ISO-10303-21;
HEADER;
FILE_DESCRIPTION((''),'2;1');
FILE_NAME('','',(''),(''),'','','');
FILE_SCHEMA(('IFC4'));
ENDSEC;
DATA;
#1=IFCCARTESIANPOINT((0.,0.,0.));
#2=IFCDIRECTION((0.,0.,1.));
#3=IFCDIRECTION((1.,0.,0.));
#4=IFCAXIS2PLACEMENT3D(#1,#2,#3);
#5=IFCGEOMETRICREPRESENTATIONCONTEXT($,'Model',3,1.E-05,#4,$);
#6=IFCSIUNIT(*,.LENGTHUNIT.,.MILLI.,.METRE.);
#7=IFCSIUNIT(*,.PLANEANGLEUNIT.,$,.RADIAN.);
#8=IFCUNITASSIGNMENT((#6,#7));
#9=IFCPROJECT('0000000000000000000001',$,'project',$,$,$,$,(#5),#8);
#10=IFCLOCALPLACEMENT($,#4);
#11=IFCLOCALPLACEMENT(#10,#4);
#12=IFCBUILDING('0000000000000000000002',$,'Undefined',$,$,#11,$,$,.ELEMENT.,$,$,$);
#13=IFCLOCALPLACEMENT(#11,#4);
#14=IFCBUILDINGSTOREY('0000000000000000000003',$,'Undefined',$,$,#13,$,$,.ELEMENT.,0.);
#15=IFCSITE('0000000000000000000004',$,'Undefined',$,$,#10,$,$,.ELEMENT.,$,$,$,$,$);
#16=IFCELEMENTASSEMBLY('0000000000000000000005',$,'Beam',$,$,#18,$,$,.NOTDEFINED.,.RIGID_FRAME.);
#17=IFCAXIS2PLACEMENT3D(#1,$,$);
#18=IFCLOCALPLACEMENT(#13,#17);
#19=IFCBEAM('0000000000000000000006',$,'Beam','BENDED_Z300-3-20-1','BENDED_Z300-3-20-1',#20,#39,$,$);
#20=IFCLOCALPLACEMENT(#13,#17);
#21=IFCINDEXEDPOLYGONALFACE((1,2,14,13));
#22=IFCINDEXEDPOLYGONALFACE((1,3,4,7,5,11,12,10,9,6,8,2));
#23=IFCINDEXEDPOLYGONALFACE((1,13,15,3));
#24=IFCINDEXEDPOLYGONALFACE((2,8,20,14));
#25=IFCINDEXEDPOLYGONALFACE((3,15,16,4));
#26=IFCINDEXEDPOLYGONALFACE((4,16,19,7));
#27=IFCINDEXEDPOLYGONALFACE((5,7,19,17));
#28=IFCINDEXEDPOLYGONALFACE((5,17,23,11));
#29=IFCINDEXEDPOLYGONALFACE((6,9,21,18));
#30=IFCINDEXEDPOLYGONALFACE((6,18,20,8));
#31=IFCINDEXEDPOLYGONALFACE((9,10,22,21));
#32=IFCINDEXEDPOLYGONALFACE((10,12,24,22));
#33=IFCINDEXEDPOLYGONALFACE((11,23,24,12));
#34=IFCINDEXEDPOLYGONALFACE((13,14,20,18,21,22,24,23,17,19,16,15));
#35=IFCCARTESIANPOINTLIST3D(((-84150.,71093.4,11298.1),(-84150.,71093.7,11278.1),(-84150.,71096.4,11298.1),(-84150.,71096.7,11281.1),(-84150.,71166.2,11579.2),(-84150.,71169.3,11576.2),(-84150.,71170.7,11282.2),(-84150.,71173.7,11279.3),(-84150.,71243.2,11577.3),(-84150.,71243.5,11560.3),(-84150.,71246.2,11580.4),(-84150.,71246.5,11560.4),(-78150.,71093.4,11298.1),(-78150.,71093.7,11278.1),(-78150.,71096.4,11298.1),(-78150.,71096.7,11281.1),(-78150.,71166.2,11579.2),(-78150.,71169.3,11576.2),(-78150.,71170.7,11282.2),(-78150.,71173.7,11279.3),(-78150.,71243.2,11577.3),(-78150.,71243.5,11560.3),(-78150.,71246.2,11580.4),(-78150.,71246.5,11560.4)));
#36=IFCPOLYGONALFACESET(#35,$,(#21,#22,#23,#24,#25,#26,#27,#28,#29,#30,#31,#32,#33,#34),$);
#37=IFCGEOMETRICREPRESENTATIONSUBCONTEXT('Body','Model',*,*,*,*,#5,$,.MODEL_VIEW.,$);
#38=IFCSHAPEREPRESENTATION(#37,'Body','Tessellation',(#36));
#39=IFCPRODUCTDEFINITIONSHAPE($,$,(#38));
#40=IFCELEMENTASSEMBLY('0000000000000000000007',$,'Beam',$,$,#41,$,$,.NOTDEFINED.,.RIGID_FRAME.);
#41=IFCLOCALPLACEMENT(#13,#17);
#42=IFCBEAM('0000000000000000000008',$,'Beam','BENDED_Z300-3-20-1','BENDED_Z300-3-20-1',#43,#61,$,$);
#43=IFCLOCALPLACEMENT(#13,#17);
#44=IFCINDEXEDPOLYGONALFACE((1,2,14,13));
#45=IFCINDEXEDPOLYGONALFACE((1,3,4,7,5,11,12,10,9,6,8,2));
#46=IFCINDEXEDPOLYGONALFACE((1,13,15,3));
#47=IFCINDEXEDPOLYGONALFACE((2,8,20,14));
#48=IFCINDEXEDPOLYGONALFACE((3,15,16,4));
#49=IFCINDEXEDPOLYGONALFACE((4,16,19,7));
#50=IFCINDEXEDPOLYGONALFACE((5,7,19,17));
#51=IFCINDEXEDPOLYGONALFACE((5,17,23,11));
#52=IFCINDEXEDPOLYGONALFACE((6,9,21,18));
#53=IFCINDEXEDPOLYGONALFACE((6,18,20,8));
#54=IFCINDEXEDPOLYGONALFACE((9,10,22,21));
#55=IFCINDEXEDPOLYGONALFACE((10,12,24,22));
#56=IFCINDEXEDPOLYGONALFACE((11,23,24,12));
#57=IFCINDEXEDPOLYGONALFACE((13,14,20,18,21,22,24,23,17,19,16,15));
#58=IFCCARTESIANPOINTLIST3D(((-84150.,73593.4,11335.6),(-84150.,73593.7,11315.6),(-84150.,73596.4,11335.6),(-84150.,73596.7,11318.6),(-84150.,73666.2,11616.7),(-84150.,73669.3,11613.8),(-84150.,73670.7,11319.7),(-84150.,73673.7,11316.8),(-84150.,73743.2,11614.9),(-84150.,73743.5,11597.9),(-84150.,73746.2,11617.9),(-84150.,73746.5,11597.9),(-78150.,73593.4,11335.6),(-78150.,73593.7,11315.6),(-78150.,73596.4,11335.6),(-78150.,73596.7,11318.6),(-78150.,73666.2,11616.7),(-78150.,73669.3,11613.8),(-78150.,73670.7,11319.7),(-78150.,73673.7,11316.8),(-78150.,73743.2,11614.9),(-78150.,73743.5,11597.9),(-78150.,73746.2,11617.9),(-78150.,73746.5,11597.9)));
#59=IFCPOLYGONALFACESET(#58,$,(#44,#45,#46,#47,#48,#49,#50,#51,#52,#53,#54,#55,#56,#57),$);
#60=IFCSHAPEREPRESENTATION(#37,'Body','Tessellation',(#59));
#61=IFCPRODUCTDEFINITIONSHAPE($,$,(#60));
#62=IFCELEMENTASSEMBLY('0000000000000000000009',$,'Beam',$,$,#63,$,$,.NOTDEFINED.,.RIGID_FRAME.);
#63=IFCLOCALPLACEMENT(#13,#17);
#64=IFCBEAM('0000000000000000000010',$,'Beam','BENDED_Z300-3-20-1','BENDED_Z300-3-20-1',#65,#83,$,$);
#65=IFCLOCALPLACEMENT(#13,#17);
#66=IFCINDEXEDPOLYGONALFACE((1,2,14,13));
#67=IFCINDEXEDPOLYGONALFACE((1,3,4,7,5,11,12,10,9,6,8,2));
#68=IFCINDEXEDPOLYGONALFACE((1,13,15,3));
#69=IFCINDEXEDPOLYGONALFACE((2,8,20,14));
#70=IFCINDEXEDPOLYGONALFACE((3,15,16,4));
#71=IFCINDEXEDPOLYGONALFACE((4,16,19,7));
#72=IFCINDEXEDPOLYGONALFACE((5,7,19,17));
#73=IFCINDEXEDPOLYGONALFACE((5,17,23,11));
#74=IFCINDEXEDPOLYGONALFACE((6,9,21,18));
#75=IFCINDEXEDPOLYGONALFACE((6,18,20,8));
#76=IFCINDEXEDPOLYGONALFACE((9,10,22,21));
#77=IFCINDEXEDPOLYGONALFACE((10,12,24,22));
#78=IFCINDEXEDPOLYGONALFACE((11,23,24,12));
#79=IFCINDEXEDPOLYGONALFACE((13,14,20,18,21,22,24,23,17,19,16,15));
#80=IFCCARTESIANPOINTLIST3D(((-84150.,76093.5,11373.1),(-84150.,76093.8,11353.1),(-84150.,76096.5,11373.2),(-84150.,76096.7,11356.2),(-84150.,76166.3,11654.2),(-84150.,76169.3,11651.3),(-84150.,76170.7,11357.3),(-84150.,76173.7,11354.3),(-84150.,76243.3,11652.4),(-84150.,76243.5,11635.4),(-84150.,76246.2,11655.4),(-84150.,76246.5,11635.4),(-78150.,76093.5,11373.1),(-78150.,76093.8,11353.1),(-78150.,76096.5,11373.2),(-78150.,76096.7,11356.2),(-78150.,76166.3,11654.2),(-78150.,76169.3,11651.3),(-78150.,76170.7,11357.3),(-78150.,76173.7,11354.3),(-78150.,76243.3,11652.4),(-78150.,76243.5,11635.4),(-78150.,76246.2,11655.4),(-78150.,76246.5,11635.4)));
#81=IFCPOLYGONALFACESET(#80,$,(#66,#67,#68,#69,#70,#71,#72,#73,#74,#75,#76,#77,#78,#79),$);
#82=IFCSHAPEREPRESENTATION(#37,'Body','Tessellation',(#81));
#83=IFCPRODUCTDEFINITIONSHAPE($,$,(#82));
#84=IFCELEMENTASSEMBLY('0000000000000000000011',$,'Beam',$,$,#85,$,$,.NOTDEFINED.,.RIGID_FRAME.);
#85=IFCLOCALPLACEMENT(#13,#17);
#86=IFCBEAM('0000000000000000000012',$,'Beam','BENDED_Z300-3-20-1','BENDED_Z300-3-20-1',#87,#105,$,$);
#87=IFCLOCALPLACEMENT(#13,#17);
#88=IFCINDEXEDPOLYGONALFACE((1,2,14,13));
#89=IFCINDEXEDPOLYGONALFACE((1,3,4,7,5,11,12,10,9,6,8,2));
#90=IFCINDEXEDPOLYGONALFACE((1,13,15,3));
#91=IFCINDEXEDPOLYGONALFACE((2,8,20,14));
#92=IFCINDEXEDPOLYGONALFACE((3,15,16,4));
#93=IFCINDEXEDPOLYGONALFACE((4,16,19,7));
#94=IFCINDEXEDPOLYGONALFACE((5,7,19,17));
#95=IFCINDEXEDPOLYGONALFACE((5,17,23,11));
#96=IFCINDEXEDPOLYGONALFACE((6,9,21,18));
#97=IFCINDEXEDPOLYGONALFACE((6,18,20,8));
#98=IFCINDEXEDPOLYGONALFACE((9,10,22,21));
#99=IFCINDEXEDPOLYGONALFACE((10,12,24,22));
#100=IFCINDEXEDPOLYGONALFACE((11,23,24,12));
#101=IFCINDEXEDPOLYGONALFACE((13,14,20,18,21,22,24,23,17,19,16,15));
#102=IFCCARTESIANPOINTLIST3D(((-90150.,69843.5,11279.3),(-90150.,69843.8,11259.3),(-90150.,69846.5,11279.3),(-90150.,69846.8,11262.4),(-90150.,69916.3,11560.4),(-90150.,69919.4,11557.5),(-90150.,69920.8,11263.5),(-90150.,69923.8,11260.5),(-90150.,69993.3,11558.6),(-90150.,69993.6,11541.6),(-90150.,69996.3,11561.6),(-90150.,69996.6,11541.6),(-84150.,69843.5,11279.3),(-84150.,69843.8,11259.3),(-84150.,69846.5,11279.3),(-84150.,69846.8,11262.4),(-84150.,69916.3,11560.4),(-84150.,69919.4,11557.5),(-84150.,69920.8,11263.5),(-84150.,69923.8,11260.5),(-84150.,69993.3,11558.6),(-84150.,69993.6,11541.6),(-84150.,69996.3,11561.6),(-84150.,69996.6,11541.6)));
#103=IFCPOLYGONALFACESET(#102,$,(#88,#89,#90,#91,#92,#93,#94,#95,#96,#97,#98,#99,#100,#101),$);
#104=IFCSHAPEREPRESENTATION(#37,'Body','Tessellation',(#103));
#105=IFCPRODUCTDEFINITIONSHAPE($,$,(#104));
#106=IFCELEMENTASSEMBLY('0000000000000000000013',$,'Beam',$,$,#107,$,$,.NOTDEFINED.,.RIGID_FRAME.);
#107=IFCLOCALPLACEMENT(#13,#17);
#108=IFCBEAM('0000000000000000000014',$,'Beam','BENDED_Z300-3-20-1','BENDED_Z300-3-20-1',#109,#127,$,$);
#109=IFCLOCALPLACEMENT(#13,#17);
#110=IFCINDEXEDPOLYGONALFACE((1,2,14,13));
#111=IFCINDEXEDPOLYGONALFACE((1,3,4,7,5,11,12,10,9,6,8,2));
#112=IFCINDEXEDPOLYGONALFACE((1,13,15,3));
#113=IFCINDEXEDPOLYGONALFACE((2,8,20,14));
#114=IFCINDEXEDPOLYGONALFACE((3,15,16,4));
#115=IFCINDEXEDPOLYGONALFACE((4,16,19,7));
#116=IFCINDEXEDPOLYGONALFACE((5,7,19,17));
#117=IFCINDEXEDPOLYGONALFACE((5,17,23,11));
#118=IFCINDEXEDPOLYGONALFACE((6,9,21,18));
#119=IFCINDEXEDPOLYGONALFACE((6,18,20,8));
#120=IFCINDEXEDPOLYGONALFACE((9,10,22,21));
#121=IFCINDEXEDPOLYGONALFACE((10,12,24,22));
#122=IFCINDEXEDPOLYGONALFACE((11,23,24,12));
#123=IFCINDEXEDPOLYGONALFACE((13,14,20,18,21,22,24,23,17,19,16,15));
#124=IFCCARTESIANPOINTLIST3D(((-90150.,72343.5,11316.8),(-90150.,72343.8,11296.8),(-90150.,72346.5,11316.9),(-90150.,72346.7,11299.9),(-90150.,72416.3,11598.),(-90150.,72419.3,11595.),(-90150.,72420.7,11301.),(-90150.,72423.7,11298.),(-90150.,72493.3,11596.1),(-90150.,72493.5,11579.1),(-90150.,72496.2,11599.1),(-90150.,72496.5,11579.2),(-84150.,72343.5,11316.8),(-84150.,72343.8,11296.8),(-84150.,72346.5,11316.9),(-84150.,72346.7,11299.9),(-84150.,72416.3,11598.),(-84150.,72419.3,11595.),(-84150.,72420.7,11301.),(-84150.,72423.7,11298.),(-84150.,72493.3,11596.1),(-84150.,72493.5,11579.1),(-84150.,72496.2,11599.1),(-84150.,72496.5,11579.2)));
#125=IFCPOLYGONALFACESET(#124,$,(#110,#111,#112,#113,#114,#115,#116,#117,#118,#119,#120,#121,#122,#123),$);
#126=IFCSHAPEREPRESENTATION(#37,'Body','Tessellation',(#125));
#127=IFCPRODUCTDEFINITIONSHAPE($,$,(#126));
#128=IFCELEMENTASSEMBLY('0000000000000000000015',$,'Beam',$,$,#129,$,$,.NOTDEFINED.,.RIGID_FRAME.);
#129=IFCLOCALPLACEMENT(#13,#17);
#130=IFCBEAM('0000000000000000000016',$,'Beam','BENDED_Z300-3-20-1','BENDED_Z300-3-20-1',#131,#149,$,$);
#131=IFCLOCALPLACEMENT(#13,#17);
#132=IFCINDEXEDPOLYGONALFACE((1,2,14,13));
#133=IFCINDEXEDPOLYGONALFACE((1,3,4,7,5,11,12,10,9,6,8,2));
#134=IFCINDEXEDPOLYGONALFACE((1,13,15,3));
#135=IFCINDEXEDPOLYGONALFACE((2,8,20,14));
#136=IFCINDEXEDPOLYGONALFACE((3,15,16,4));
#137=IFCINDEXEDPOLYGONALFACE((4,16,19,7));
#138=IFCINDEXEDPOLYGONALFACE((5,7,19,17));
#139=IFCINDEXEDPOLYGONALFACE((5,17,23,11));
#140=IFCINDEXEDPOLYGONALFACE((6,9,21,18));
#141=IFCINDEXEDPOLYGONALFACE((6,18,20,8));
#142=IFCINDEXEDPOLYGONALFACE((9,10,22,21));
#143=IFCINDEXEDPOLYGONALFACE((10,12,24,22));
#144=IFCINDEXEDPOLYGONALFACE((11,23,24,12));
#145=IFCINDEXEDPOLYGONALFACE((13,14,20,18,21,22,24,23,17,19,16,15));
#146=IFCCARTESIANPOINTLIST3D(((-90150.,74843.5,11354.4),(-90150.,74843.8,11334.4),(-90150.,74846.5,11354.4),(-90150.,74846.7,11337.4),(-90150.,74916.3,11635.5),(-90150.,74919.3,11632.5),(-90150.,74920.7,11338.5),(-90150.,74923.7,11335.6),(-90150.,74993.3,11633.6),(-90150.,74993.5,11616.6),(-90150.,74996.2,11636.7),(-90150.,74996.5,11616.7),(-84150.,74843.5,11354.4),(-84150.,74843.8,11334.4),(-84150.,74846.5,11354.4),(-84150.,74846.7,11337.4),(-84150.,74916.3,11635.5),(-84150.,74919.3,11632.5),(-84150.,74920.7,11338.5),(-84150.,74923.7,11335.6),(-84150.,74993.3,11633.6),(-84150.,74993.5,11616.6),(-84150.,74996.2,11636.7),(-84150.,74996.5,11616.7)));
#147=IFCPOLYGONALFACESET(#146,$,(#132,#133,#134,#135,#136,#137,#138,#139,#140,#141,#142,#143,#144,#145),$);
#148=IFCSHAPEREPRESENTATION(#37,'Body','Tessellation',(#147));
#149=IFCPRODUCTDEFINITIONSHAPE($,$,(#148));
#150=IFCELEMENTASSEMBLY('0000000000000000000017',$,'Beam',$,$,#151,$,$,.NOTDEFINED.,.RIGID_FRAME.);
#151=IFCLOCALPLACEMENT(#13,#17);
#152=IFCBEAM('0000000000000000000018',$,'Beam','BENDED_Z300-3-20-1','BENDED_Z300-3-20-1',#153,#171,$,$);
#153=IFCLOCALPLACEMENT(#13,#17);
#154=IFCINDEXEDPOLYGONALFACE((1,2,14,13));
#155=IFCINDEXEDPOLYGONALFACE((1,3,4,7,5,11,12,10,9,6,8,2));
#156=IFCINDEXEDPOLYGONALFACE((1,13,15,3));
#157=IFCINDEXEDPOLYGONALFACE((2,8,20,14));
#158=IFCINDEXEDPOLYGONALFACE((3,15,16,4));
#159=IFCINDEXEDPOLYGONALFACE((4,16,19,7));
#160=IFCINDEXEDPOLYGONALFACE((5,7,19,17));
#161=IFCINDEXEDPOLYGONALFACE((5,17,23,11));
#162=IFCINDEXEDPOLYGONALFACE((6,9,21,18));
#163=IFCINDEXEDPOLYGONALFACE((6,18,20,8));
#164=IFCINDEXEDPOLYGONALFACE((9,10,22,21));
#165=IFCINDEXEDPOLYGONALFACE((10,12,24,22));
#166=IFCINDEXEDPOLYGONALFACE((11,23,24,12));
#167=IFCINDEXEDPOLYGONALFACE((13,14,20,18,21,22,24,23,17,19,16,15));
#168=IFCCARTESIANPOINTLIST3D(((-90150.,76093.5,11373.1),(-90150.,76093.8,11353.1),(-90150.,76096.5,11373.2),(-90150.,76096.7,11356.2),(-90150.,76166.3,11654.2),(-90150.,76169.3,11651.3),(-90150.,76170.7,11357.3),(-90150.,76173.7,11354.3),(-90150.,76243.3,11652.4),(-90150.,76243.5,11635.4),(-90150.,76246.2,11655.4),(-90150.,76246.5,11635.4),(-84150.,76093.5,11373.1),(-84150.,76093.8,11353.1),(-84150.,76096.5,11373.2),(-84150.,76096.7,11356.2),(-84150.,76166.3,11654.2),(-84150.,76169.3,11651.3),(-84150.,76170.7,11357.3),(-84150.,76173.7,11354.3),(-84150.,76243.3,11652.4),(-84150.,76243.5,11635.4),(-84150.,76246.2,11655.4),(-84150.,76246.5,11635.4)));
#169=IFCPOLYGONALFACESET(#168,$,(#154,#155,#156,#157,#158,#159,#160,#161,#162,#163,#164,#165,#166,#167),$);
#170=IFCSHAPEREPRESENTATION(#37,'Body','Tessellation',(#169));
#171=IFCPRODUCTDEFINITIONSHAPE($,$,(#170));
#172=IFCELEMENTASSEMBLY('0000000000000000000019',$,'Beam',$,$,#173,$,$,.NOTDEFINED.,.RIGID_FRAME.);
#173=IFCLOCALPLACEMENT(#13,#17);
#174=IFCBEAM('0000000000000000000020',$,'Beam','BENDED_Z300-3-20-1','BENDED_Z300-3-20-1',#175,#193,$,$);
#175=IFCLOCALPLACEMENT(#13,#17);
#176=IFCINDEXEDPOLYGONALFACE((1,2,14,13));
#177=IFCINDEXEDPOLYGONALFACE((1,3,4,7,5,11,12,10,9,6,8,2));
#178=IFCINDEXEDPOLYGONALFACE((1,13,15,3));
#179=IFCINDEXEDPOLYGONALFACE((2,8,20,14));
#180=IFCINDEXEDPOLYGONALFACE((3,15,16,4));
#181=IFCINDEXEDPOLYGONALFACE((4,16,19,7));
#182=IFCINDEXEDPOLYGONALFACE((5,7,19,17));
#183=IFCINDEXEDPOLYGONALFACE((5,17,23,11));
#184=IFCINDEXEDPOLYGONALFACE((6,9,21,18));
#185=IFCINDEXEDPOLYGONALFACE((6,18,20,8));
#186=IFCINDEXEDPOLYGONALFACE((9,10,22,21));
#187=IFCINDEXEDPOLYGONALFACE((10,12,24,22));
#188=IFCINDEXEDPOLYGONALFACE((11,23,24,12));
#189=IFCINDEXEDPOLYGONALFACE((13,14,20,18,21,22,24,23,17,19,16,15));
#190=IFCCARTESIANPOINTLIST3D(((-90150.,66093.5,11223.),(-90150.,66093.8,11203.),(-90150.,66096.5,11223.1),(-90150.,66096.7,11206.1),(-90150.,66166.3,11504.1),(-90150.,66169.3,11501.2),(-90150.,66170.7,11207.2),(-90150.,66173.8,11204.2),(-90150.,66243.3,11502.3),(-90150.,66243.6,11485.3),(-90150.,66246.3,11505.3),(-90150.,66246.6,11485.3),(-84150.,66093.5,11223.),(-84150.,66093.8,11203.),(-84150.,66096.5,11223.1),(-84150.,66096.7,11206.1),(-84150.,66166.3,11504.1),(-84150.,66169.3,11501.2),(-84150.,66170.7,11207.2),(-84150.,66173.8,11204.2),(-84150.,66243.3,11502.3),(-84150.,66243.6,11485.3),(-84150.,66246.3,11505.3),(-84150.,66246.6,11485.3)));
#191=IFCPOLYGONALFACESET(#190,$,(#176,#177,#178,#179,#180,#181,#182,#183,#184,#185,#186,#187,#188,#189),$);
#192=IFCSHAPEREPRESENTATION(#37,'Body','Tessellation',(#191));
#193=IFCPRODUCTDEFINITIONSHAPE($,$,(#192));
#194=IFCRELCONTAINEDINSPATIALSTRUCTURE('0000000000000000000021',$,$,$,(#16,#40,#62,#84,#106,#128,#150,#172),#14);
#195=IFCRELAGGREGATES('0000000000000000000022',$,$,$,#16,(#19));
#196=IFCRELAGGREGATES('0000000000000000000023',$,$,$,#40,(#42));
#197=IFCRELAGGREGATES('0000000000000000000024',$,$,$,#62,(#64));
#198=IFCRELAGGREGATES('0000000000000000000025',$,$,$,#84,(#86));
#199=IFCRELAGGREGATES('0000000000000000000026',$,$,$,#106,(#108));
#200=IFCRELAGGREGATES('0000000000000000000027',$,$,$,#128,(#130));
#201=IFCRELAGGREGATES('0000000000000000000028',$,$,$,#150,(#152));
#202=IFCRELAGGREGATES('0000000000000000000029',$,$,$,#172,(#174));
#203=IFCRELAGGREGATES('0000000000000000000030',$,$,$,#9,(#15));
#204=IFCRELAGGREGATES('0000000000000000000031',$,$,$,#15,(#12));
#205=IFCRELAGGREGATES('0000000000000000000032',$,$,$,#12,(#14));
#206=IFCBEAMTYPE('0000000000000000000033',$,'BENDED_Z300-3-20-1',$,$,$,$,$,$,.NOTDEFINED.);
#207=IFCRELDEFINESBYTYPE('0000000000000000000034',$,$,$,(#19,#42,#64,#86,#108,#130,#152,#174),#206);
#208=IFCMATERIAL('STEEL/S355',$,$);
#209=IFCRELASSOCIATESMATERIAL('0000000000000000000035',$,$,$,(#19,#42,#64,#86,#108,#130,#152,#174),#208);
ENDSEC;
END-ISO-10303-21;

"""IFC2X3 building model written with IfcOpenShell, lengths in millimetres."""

from ifc_helpers import new_model, si_unit, frame, origin_with_axes, place, context, subcontext, project, spatial, polyline, outline, extrude, material, type_object, element, aggregate, save


model = new_model("IFC2X3")

# Units and contexts
model_context = context("Model", 3, precision=1e-05, world=origin_with_axes())
body_context = subcontext(model_context, "Body", "Model", "MODEL_VIEW")
ifc_project = project(units=[si_unit("LENGTHUNIT", "METRE", prefix="MILLI"), si_unit("PLANEANGLEUNIT", "RADIAN")], contexts=[model_context])

# Site, building, storey
site_placement = place(None, origin_with_axes())
site = spatial("IfcSite", under=ifc_project, at=site_placement, Name="Undefined", CompositionType="ELEMENT")
building_placement = place(site_placement, origin_with_axes())
building = spatial("IfcBuilding", under=site, at=building_placement, Name="Undefined", CompositionType="ELEMENT")
storey_placement = place(building_placement, origin_with_axes())
storey = spatial("IfcBuildingStorey", under=building, at=storey_placement, Name="Undefined", CompositionType="ELEMENT", Elevation=0.0)

# Shared definitions
ifc_material_1 = material(Name="STEEL/S355")

# Element assemblies, beams
beam_type_1 = type_object("IfcBeamType", Name="BENDED_Z300-3-20-1", PredefinedType="NOTDEFINED")
assembly_1_placement = place(storey_placement, origin_with_axes())
assembly_1 = element("IfcElementAssembly", 1, at=assembly_1_placement, inside=storey, Name="Beam", AssemblyPlace="NOTDEFINED", PredefinedType="RIGID_FRAME")
beam_1_placement = place(assembly_1_placement, frame((-78150.0, 71170.0, 11429.2), z_axis=(0.0, -0.014963, 0.999888), x_axis=(-1.0, 0.0, 0.0)))
beam_1 = element("IfcBeam", 2, at=beam_1_placement, type_object=beam_type_1, material=ifc_material_1, Name="Beam", Description="BENDED_Z300-3-20-1", ObjectType="BENDED_Z300-3-20-1", context=body_context, shape_type="SweptSolid", body=[
    extrude(outline(polyline([(1.5, -150.0), (-78.5, -150.0), (-78.5, -130.0), (-75.5, -130.0), (-75.5, -147.0), (-1.5, -147.0), (-1.5, 150.0), (78.5, 150.0), (78.5, 130.0), (75.5, 130.0), (75.5, 147.0), (1.5, 147.0), (1.5, -150.0)])), frame((6000.0, 0.0, 0.0), z_axis=(-1.0, 0.0, 0.0), x_axis=(0.0, -1.0, 0.0)), (0.0, 0.0, 1.0), 6000.0),
])
aggregate(assembly_1, [beam_1])
assembly_2_placement = place(storey_placement, origin_with_axes())
assembly_2 = element("IfcElementAssembly", 3, at=assembly_2_placement, inside=storey, Name="Beam", AssemblyPlace="NOTDEFINED", PredefinedType="RIGID_FRAME")
beam_2_placement = place(assembly_2_placement, frame((-78150.0, 73670.0, 11466.8), z_axis=(0.0, -0.014963, 0.999888), x_axis=(-1.0, 0.0, 0.0)))
beam_2 = element("IfcBeam", 4, at=beam_2_placement, type_object=beam_type_1, material=ifc_material_1, Name="Beam", Description="BENDED_Z300-3-20-1", ObjectType="BENDED_Z300-3-20-1", context=body_context, shape_type="SweptSolid", body=[
    extrude(outline(polyline([(1.5, -150.0), (-78.5, -150.0), (-78.5, -130.0), (-75.5, -130.0), (-75.5, -147.0), (-1.5, -147.0), (-1.5, 150.0), (78.5, 150.0), (78.5, 130.0), (75.5, 130.0), (75.5, 147.0), (1.5, 147.0), (1.5, -150.0)])), frame((6000.0, 0.0, 0.0), z_axis=(-1.0, 0.0, 0.0), x_axis=(0.0, -1.0, 0.0)), (0.0, 0.0, 1.0), 6000.0),
])
aggregate(assembly_2, [beam_2])
assembly_3_placement = place(storey_placement, origin_with_axes())
assembly_3 = element("IfcElementAssembly", 5, at=assembly_3_placement, inside=storey, Name="Beam", AssemblyPlace="NOTDEFINED", PredefinedType="RIGID_FRAME")
beam_3_placement = place(assembly_3_placement, frame((-78150.0, 76170.0, 11504.3), z_axis=(0.0, -0.014963, 0.999888), x_axis=(-1.0, 0.0, 0.0)))
beam_3 = element("IfcBeam", 6, at=beam_3_placement, type_object=beam_type_1, material=ifc_material_1, Name="Beam", Description="BENDED_Z300-3-20-1", ObjectType="BENDED_Z300-3-20-1", context=body_context, shape_type="SweptSolid", body=[
    extrude(outline(polyline([(1.5, -150.0), (-78.5, -150.0), (-78.5, -130.0), (-75.5, -130.0), (-75.5, -147.0), (-1.5, -147.0), (-1.5, 150.0), (78.5, 150.0), (78.5, 130.0), (75.5, 130.0), (75.5, 147.0), (1.5, 147.0), (1.5, -150.0)])), frame((6000.0, 0.0, 0.0), z_axis=(-1.0, 0.0, 0.0), x_axis=(0.0, -1.0, 0.0)), (0.0, 0.0, 1.0), 6000.0),
])
aggregate(assembly_3, [beam_3])
assembly_4_placement = place(storey_placement, origin_with_axes())
assembly_4 = element("IfcElementAssembly", 7, at=assembly_4_placement, inside=storey, Name="Beam", AssemblyPlace="NOTDEFINED", PredefinedType="RIGID_FRAME")
beam_4_placement = place(assembly_4_placement, frame((-84150.0, 69920.1, 11410.5), z_axis=(0.0, -0.014963, 0.999888), x_axis=(-1.0, 0.0, 0.0)))
beam_4 = element("IfcBeam", 8, at=beam_4_placement, type_object=beam_type_1, material=ifc_material_1, Name="Beam", Description="BENDED_Z300-3-20-1", ObjectType="BENDED_Z300-3-20-1", context=body_context, shape_type="SweptSolid", body=[
    extrude(outline(polyline([(1.5, -150.0), (-78.5, -150.0), (-78.5, -130.0), (-75.5, -130.0), (-75.5, -147.0), (-1.5, -147.0), (-1.5, 150.0), (78.5, 150.0), (78.5, 130.0), (75.5, 130.0), (75.5, 147.0), (1.5, 147.0), (1.5, -150.0)])), frame((6000.0, 0.0, 0.0), z_axis=(-1.0, 0.0, 0.0), x_axis=(0.0, -1.0, 0.0)), (0.0, 0.0, 1.0), 6000.0),
])
aggregate(assembly_4, [beam_4])
assembly_5_placement = place(storey_placement, origin_with_axes())
assembly_5 = element("IfcElementAssembly", 9, at=assembly_5_placement, inside=storey, Name="Beam", AssemblyPlace="NOTDEFINED", PredefinedType="RIGID_FRAME")
beam_5_placement = place(assembly_5_placement, frame((-84150.0, 72420.0, 11448.0), z_axis=(0.0, -0.014963, 0.999888), x_axis=(-1.0, 0.0, 0.0)))
beam_5 = element("IfcBeam", 10, at=beam_5_placement, type_object=beam_type_1, material=ifc_material_1, Name="Beam", Description="BENDED_Z300-3-20-1", ObjectType="BENDED_Z300-3-20-1", context=body_context, shape_type="SweptSolid", body=[
    extrude(outline(polyline([(1.5, -150.0), (-78.5, -150.0), (-78.5, -130.0), (-75.5, -130.0), (-75.5, -147.0), (-1.5, -147.0), (-1.5, 150.0), (78.5, 150.0), (78.5, 130.0), (75.5, 130.0), (75.5, 147.0), (1.5, 147.0), (1.5, -150.0)])), frame((6000.0, 0.0, 0.0), z_axis=(-1.0, 0.0, 0.0), x_axis=(0.0, -1.0, 0.0)), (0.0, 0.0, 1.0), 6000.0),
])
aggregate(assembly_5, [beam_5])
assembly_6_placement = place(storey_placement, origin_with_axes())
assembly_6 = element("IfcElementAssembly", 11, at=assembly_6_placement, inside=storey, Name="Beam", AssemblyPlace="NOTDEFINED", PredefinedType="RIGID_FRAME")
beam_6_placement = place(assembly_6_placement, frame((-84150.0, 74920.0, 11485.5), z_axis=(0.0, -0.014963, 0.999888), x_axis=(-1.0, 0.0, 0.0)))
beam_6 = element("IfcBeam", 12, at=beam_6_placement, type_object=beam_type_1, material=ifc_material_1, Name="Beam", Description="BENDED_Z300-3-20-1", ObjectType="BENDED_Z300-3-20-1", context=body_context, shape_type="SweptSolid", body=[
    extrude(outline(polyline([(1.5, -150.0), (-78.5, -150.0), (-78.5, -130.0), (-75.5, -130.0), (-75.5, -147.0), (-1.5, -147.0), (-1.5, 150.0), (78.5, 150.0), (78.5, 130.0), (75.5, 130.0), (75.5, 147.0), (1.5, 147.0), (1.5, -150.0)])), frame((6000.0, 0.0, 0.0), z_axis=(-1.0, 0.0, 0.0), x_axis=(0.0, -1.0, 0.0)), (0.0, 0.0, 1.0), 6000.0),
])
aggregate(assembly_6, [beam_6])
assembly_7_placement = place(storey_placement, origin_with_axes())
assembly_7 = element("IfcElementAssembly", 13, at=assembly_7_placement, inside=storey, Name="Beam", AssemblyPlace="NOTDEFINED", PredefinedType="RIGID_FRAME")
beam_7_placement = place(assembly_7_placement, frame((-84150.0, 76170.0, 11504.3), z_axis=(0.0, -0.014963, 0.999888), x_axis=(-1.0, 0.0, 0.0)))
beam_7 = element("IfcBeam", 14, at=beam_7_placement, type_object=beam_type_1, material=ifc_material_1, Name="Beam", Description="BENDED_Z300-3-20-1", ObjectType="BENDED_Z300-3-20-1", context=body_context, shape_type="SweptSolid", body=[
    extrude(outline(polyline([(1.5, -150.0), (-78.5, -150.0), (-78.5, -130.0), (-75.5, -130.0), (-75.5, -147.0), (-1.5, -147.0), (-1.5, 150.0), (78.5, 150.0), (78.5, 130.0), (75.5, 130.0), (75.5, 147.0), (1.5, 147.0), (1.5, -150.0)])), frame((6000.0, 0.0, 0.0), z_axis=(-1.0, 0.0, 0.0), x_axis=(0.0, -1.0, 0.0)), (0.0, 0.0, 1.0), 6000.0),
])
aggregate(assembly_7, [beam_7])
assembly_8_placement = place(storey_placement, origin_with_axes())
assembly_8 = element("IfcElementAssembly", 15, at=assembly_8_placement, inside=storey, Name="Beam", AssemblyPlace="NOTDEFINED", PredefinedType="RIGID_FRAME")
beam_8_placement = place(assembly_8_placement, frame((-84150.0, 66170.0, 11354.2), z_axis=(0.0, -0.014963, 0.999888), x_axis=(-1.0, 0.0, 0.0)))
beam_8 = element("IfcBeam", 16, at=beam_8_placement, type_object=beam_type_1, material=ifc_material_1, Name="Beam", Description="BENDED_Z300-3-20-1", ObjectType="BENDED_Z300-3-20-1", context=body_context, shape_type="SweptSolid", body=[
    extrude(outline(polyline([(1.5, -150.0), (-78.5, -150.0), (-78.5, -130.0), (-75.5, -130.0), (-75.5, -147.0), (-1.5, -147.0), (-1.5, 150.0), (78.5, 150.0), (78.5, 130.0), (75.5, 130.0), (75.5, 147.0), (1.5, 147.0), (1.5, -150.0)])), frame((6000.0, 0.0, 0.0), z_axis=(-1.0, 0.0, 0.0), x_axis=(0.0, -1.0, 0.0)), (0.0, 0.0, 1.0), 6000.0),
])
aggregate(assembly_8, [beam_8])

save(model, "model.ifc")
